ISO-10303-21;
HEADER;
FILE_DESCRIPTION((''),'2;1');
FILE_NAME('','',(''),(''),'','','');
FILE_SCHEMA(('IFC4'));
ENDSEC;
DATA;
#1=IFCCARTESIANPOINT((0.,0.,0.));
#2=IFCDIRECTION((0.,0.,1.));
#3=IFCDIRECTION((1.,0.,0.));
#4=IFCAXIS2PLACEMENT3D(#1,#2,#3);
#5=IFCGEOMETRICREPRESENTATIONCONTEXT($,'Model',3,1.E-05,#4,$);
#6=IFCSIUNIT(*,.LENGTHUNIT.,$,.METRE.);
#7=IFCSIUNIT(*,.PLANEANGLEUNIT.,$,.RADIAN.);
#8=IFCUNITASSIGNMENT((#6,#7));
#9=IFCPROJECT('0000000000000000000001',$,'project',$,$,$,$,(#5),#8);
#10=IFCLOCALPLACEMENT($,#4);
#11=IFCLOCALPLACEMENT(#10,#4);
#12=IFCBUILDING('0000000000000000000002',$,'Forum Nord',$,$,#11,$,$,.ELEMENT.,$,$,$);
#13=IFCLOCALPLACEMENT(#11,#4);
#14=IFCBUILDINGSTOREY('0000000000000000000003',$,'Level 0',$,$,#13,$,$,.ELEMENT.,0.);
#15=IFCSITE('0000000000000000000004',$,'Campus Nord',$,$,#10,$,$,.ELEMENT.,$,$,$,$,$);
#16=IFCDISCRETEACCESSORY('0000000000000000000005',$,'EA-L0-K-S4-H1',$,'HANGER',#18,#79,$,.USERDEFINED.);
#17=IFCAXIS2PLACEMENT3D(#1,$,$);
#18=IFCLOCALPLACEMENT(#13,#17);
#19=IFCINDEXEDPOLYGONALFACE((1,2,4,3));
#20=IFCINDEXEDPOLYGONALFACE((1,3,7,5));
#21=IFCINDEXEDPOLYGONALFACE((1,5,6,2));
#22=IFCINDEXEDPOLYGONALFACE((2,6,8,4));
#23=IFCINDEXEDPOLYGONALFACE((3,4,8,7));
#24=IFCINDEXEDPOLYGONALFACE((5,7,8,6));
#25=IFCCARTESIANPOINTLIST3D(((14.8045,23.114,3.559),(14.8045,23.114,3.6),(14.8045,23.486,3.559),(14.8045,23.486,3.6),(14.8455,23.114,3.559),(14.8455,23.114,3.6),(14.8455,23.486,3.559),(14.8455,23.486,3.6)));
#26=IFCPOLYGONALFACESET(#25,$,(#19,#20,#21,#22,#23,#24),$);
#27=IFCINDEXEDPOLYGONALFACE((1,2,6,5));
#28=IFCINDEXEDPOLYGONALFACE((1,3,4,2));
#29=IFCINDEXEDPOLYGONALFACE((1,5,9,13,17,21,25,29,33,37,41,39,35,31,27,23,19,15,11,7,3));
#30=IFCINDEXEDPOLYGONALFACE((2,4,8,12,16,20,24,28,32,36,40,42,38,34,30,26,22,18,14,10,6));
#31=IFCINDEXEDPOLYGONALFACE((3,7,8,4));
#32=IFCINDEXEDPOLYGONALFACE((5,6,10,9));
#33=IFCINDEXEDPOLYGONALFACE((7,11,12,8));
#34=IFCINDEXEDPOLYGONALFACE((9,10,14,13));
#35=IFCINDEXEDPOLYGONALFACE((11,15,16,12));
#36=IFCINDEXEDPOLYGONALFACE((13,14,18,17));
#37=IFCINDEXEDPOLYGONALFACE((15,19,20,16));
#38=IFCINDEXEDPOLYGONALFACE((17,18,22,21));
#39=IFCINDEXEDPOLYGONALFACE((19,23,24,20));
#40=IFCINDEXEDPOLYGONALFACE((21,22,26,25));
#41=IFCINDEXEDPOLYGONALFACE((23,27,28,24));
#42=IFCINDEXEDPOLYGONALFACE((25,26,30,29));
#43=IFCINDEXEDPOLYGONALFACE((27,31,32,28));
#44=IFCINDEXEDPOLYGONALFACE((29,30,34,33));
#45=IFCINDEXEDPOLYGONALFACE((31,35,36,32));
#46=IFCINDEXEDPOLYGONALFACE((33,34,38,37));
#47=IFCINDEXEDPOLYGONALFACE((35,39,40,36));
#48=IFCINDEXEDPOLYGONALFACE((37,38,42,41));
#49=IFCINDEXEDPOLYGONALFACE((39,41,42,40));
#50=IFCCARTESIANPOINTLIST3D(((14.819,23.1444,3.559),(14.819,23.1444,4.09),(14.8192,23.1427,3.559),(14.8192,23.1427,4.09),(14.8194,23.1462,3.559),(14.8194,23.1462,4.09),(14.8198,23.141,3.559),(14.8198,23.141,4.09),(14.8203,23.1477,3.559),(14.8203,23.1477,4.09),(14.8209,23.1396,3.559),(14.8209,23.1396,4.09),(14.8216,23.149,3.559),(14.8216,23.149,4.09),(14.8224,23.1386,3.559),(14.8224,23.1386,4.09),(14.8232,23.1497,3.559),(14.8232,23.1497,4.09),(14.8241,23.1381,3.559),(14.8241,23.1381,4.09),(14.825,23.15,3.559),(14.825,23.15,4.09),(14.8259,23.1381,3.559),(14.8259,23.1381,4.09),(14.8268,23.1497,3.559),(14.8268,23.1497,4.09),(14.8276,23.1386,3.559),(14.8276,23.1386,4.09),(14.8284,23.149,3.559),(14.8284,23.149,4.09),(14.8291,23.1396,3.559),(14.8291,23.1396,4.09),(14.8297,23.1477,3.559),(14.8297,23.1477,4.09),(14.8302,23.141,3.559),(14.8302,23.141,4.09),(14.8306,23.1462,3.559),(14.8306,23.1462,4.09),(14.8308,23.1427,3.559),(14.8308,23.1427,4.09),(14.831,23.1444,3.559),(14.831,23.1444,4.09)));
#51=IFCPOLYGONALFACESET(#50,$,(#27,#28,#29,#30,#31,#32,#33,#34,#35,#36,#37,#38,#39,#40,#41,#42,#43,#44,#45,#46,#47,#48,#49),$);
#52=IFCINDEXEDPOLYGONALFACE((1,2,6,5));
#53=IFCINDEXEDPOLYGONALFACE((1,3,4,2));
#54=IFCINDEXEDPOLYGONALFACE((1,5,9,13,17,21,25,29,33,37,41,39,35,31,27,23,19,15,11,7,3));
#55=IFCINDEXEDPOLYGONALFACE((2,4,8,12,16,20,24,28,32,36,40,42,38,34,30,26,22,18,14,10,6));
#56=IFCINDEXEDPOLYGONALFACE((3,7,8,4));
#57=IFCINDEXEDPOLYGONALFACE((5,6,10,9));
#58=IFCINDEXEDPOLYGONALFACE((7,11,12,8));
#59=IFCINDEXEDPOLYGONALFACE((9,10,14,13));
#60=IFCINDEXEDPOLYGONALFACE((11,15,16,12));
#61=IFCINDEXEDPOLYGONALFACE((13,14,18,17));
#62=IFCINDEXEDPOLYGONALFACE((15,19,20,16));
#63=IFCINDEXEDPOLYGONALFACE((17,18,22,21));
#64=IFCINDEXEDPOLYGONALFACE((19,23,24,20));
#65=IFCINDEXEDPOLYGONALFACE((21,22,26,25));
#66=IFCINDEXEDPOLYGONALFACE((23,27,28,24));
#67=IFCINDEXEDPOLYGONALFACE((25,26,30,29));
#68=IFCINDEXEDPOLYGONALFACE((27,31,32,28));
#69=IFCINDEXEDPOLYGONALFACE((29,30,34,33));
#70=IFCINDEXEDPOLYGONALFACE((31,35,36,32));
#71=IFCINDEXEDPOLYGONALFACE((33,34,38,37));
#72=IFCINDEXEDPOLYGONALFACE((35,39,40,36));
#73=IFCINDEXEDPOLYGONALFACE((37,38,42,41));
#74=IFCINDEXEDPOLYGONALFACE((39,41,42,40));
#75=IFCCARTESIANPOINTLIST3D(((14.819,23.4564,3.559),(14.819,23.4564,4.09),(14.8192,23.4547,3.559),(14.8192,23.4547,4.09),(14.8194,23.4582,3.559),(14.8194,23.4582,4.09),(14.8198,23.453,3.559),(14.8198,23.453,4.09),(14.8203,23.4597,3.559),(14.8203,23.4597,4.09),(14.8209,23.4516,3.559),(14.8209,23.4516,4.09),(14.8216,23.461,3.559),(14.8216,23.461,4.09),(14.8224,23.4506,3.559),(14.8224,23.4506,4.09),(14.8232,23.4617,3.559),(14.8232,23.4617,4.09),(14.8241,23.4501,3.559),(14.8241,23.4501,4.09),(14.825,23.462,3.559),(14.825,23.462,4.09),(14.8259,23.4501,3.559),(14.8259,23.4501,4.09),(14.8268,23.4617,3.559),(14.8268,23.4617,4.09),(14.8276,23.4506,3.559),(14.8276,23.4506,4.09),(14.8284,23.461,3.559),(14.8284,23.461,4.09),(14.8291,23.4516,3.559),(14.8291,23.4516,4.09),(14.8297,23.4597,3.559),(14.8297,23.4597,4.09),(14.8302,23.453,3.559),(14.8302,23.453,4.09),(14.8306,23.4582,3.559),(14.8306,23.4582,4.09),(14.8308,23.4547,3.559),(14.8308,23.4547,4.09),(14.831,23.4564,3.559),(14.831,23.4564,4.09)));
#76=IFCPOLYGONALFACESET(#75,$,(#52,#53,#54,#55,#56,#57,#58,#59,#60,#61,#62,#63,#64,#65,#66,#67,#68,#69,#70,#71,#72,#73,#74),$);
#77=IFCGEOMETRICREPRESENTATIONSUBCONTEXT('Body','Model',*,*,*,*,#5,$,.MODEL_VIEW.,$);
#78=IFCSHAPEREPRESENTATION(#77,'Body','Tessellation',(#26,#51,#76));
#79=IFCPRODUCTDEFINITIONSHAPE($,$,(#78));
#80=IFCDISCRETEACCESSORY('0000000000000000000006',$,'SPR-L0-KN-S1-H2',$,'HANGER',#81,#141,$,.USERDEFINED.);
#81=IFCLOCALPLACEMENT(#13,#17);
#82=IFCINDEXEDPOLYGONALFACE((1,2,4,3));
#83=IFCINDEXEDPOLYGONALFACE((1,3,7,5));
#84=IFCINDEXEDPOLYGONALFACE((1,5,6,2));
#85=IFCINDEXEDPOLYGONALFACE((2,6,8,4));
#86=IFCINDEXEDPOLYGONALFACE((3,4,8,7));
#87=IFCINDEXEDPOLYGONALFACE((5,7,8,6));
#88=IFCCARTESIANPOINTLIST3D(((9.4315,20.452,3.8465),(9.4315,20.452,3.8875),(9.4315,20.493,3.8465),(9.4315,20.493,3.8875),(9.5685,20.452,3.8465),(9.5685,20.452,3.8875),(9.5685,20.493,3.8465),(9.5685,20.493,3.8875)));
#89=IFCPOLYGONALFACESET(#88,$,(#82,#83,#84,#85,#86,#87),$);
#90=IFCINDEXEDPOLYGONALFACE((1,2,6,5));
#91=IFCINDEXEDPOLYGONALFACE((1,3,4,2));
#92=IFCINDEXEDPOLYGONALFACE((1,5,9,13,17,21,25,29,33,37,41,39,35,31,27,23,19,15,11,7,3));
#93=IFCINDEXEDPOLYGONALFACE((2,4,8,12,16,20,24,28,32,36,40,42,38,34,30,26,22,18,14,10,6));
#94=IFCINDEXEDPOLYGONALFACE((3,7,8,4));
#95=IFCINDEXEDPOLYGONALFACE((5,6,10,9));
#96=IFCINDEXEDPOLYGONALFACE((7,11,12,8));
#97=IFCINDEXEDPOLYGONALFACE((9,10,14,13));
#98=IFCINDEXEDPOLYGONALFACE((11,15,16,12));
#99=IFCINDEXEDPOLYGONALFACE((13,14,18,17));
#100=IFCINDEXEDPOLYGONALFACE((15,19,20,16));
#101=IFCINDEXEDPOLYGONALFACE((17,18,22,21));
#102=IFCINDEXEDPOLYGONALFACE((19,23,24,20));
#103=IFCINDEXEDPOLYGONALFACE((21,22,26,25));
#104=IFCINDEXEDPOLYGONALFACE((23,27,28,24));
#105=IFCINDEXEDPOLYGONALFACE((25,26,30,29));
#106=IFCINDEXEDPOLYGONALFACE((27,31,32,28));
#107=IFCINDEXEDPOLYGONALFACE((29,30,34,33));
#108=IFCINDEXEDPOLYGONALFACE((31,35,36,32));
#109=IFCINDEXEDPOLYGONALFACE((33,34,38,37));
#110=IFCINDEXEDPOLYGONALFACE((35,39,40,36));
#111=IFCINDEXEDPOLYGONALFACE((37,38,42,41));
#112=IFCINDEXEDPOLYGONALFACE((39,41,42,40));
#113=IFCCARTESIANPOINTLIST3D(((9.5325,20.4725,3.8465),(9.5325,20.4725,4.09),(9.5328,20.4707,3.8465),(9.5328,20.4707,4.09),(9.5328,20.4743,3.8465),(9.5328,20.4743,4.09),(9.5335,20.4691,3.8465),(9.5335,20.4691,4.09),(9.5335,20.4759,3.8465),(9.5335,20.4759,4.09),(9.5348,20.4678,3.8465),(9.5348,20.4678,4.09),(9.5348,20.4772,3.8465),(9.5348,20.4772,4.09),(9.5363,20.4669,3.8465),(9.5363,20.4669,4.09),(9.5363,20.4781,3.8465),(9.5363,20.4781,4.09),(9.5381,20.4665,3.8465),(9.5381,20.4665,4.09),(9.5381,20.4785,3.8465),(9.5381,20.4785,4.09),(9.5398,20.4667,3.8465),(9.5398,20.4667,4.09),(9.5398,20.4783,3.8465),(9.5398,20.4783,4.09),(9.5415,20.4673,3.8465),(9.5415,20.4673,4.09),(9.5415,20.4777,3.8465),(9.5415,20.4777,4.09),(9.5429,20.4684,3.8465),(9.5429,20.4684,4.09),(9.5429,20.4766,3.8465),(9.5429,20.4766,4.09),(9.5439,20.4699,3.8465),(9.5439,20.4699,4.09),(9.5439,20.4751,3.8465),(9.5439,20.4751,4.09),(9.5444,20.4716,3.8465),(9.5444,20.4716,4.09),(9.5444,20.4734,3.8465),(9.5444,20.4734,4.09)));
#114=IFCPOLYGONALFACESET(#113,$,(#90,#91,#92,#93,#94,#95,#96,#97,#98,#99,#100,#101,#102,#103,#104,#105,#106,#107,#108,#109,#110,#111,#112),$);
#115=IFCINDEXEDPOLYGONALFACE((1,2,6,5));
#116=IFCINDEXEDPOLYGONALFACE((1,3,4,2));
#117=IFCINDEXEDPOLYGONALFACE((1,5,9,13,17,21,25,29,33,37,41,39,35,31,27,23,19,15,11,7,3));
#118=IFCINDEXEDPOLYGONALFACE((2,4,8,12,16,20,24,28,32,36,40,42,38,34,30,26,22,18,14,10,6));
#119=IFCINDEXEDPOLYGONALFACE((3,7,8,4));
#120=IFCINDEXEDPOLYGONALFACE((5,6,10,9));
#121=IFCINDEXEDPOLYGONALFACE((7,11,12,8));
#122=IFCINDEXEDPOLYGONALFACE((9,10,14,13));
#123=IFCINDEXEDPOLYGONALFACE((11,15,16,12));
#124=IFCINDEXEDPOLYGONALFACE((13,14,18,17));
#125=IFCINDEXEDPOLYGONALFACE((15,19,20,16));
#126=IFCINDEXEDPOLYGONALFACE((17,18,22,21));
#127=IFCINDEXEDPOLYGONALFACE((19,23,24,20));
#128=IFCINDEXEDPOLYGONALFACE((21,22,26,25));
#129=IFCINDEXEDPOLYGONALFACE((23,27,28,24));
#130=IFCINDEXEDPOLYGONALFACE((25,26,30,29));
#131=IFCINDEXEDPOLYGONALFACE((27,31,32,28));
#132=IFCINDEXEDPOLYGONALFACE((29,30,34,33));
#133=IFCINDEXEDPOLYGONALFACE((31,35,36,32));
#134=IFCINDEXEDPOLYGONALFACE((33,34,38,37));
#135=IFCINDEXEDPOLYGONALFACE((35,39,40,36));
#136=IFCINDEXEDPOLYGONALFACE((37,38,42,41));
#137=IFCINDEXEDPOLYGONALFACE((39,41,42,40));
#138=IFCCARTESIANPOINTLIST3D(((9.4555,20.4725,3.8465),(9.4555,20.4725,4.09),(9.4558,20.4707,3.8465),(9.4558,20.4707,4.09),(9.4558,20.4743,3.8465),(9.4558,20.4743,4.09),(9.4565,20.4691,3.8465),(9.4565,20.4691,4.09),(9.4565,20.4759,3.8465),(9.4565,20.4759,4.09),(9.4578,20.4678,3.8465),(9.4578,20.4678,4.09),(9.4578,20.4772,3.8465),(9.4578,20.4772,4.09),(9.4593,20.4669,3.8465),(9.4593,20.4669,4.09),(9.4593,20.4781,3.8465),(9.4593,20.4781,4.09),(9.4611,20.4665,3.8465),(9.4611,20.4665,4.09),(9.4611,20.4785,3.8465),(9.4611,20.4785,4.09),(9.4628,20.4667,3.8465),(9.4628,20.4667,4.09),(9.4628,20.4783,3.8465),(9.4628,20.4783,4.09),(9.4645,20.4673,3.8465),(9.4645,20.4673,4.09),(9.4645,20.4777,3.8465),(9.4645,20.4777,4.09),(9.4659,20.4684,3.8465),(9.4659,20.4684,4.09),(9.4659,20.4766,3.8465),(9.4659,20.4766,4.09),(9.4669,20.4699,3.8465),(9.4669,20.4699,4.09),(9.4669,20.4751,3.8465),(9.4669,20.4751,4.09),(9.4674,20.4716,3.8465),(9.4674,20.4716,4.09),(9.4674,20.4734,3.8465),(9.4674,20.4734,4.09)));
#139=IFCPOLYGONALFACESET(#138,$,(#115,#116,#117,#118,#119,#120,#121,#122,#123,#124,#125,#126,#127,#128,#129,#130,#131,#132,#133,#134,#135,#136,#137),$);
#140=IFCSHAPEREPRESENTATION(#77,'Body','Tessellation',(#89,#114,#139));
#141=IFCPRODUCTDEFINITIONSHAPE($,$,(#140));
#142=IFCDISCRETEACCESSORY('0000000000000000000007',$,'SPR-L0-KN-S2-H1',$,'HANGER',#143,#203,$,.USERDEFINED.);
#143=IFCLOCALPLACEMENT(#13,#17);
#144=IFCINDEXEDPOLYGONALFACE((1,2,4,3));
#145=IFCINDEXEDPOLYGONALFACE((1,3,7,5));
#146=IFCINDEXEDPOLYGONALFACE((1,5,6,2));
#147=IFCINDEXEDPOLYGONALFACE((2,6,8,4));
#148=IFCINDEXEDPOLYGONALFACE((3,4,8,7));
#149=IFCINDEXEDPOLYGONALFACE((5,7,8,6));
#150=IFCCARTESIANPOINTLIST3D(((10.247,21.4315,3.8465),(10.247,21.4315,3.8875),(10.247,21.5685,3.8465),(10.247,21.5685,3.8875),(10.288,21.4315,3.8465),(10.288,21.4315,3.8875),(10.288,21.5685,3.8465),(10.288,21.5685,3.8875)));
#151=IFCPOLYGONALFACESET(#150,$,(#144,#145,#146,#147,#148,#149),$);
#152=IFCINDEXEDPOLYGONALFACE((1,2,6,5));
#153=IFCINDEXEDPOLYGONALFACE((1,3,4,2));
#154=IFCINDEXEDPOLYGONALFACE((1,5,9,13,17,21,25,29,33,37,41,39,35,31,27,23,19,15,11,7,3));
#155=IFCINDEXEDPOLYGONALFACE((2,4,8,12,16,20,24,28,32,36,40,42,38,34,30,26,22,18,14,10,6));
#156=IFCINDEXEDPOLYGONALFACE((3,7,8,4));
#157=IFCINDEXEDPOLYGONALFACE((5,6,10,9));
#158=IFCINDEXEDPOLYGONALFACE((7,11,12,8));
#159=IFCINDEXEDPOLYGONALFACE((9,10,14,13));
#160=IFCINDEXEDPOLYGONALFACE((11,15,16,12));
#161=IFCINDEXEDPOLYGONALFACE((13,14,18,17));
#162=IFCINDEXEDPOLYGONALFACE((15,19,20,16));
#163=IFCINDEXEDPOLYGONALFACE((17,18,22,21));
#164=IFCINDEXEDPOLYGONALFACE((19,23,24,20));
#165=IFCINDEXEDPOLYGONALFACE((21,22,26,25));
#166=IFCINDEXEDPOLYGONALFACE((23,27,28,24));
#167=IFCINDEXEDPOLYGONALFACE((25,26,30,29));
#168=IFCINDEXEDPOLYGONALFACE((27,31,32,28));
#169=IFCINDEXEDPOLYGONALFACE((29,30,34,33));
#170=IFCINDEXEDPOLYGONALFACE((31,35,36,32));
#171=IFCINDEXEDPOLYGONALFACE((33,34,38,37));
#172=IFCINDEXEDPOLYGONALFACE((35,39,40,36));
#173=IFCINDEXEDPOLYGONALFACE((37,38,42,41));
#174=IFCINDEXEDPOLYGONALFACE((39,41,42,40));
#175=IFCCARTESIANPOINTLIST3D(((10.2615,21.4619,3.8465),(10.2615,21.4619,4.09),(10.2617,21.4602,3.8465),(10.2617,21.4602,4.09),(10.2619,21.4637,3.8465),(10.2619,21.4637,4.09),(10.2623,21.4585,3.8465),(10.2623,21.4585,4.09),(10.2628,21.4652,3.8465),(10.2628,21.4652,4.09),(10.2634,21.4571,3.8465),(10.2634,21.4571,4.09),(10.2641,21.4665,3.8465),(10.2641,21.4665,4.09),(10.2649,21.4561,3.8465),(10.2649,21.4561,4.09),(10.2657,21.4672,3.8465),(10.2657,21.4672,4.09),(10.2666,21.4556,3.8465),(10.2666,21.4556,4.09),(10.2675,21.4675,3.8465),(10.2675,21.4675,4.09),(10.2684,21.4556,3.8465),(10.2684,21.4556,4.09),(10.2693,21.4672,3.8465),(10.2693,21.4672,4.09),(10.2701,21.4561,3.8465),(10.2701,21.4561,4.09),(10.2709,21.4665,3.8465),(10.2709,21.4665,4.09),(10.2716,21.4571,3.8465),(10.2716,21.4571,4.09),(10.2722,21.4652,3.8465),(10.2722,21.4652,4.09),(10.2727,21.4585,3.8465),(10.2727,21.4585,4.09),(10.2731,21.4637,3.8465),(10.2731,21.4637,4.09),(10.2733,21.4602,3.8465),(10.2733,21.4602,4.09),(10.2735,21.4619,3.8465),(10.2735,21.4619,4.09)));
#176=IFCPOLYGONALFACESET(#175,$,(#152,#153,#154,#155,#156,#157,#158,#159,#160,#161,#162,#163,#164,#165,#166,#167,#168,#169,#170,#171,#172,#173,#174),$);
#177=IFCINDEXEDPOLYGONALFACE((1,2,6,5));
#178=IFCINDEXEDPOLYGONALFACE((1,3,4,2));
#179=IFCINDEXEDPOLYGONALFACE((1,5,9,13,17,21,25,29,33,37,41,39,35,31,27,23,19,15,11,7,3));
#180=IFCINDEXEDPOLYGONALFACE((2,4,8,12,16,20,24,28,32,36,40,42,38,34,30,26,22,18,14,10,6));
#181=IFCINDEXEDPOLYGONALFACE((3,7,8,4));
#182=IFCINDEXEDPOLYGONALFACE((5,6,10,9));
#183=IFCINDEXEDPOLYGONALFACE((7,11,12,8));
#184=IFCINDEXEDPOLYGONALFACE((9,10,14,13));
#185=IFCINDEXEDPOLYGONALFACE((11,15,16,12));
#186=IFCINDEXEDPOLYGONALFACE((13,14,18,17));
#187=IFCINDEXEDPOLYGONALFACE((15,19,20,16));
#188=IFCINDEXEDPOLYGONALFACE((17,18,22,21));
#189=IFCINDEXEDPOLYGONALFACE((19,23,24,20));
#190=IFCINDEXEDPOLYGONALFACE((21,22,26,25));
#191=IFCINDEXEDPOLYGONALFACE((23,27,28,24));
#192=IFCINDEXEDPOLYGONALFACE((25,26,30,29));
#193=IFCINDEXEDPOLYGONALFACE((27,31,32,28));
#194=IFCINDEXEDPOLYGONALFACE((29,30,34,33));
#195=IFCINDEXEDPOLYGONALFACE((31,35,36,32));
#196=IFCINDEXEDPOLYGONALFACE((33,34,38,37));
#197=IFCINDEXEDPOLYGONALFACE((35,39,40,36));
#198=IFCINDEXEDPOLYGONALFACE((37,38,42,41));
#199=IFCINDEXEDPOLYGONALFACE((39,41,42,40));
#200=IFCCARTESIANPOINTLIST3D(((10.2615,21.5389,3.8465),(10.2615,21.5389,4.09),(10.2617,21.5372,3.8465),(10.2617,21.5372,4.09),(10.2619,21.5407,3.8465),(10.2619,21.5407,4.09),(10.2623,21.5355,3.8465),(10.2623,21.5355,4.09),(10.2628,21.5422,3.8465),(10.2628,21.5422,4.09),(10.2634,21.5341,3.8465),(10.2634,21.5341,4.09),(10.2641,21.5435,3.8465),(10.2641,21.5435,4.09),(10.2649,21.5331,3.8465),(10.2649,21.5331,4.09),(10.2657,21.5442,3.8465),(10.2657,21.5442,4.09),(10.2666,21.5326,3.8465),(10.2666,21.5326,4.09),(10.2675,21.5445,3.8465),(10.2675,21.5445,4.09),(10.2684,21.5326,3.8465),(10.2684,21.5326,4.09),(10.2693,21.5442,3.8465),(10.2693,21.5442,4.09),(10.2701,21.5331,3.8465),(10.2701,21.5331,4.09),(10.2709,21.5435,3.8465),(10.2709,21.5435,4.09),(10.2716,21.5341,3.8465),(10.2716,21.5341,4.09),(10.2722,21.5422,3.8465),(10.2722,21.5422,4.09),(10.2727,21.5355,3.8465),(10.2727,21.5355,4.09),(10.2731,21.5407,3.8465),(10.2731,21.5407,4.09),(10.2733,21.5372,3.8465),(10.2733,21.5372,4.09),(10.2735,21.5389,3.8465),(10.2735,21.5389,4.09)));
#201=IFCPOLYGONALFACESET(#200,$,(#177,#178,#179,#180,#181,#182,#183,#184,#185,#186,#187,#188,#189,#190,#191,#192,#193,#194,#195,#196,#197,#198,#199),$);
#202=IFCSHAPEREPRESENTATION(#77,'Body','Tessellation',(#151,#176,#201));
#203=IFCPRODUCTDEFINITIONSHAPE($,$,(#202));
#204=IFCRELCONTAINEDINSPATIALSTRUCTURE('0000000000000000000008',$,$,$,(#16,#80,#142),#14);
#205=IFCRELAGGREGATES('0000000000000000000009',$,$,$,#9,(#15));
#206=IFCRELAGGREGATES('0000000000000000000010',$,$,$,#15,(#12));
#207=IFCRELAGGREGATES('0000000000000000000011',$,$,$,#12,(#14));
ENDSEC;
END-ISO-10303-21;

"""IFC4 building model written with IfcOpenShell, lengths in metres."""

from ifc_helpers import new_model, si_unit, frame, frame_2d, origin_with_axes, origin_2d_with_axis, place, context, subcontext, project, spatial, rectangle, circle, extrude, element, save


model = new_model("IFC4")

# Units and contexts
model_context = context("Model", 3, precision=1e-05, world=origin_with_axes())
body_context = subcontext(model_context, "Body", "Model", "MODEL_VIEW")
ifc_project = project(units=[si_unit("LENGTHUNIT", "METRE"), si_unit("PLANEANGLEUNIT", "RADIAN")], contexts=[model_context])

# Site, building, storey
site_placement = place(None, origin_with_axes())
site = spatial("IfcSite", under=ifc_project, at=site_placement, Name="Campus Nord", CompositionType="ELEMENT")
building_placement = place(site_placement, origin_with_axes())
building = spatial("IfcBuilding", under=site, at=building_placement, Name="Forum Nord", CompositionType="ELEMENT")
storey_placement = place(building_placement, origin_with_axes())
storey = spatial("IfcBuildingStorey", under=building, at=storey_placement, Name="Level 0", CompositionType="ELEMENT", Elevation=0.0)

# Discrete accessories
for number, where, z_axis, x_axis, name in (
    (1, (14.825, 23.3, 3.6), (0.0, 0.0, 1.0), (0.0, 1.0, 0.0), "EA-L0-K-S4-H1"),
):
    element("IfcDiscreteAccessory", number, at=place(storey_placement, frame(where, z_axis=z_axis, x_axis=x_axis)), inside=storey, Name=name, ObjectType="HANGER", PredefinedType="USERDEFINED", context=body_context, shape_type="SweptSolid", body=[
        extrude(rectangle(XDim=0.372, YDim=0.041, at=origin_2d_with_axis()), frame((0.0, 0.0, -0.041), z_axis=(0.0, 0.0, 1.0), x_axis=(1.0, 0.0, 0.0)), (0.0, 0.0, 1.0), 0.041),
        extrude(circle(Radius=0.006, at=frame_2d((-0.156, 0.0), x_axis=(1.0, 0.0))), frame((0.0, 0.0, -0.041), z_axis=(0.0, 0.0, 1.0), x_axis=(1.0, 0.0, 0.0)), (0.0, 0.0, 1.0), 0.531),
        extrude(circle(Radius=0.006, at=frame_2d((0.156, 0.0), x_axis=(1.0, 0.0))), frame((0.0, 0.0, -0.041), z_axis=(0.0, 0.0, 1.0), x_axis=(1.0, 0.0, 0.0)), (0.0, 0.0, 1.0), 0.531),
    ])
for number, where, z_axis, x_axis, name in (
    (2, (9.5, 20.4725, 3.8875), (0.0, 0.0, 1.0), (-1.0, 0.0, 0.0), "SPR-L0-KN-S1-H2"),
    (3, (10.2675, 21.5, 3.8875), (0.0, 0.0, 1.0), (0.0, 1.0, 0.0), "SPR-L0-KN-S2-H1"),
):
    element("IfcDiscreteAccessory", number, at=place(storey_placement, frame(where, z_axis=z_axis, x_axis=x_axis)), inside=storey, Name=name, ObjectType="HANGER", PredefinedType="USERDEFINED", context=body_context, shape_type="SweptSolid", body=[
        extrude(rectangle(XDim=0.137, YDim=0.041, at=origin_2d_with_axis()), frame((0.0, 0.0, -0.041), z_axis=(0.0, 0.0, 1.0), x_axis=(1.0, 0.0, 0.0)), (0.0, 0.0, 1.0), 0.041),
        extrude(circle(Radius=0.006, at=frame_2d((-0.0385, 0.0), x_axis=(1.0, 0.0))), frame((0.0, 0.0, -0.041), z_axis=(0.0, 0.0, 1.0), x_axis=(1.0, 0.0, 0.0)), (0.0, 0.0, 1.0), 0.2435),
        extrude(circle(Radius=0.006, at=frame_2d((0.0385, 0.0), x_axis=(1.0, 0.0))), frame((0.0, 0.0, -0.041), z_axis=(0.0, 0.0, 1.0), x_axis=(1.0, 0.0, 0.0)), (0.0, 0.0, 1.0), 0.2435),
    ])

save(model, "model.ifc")
